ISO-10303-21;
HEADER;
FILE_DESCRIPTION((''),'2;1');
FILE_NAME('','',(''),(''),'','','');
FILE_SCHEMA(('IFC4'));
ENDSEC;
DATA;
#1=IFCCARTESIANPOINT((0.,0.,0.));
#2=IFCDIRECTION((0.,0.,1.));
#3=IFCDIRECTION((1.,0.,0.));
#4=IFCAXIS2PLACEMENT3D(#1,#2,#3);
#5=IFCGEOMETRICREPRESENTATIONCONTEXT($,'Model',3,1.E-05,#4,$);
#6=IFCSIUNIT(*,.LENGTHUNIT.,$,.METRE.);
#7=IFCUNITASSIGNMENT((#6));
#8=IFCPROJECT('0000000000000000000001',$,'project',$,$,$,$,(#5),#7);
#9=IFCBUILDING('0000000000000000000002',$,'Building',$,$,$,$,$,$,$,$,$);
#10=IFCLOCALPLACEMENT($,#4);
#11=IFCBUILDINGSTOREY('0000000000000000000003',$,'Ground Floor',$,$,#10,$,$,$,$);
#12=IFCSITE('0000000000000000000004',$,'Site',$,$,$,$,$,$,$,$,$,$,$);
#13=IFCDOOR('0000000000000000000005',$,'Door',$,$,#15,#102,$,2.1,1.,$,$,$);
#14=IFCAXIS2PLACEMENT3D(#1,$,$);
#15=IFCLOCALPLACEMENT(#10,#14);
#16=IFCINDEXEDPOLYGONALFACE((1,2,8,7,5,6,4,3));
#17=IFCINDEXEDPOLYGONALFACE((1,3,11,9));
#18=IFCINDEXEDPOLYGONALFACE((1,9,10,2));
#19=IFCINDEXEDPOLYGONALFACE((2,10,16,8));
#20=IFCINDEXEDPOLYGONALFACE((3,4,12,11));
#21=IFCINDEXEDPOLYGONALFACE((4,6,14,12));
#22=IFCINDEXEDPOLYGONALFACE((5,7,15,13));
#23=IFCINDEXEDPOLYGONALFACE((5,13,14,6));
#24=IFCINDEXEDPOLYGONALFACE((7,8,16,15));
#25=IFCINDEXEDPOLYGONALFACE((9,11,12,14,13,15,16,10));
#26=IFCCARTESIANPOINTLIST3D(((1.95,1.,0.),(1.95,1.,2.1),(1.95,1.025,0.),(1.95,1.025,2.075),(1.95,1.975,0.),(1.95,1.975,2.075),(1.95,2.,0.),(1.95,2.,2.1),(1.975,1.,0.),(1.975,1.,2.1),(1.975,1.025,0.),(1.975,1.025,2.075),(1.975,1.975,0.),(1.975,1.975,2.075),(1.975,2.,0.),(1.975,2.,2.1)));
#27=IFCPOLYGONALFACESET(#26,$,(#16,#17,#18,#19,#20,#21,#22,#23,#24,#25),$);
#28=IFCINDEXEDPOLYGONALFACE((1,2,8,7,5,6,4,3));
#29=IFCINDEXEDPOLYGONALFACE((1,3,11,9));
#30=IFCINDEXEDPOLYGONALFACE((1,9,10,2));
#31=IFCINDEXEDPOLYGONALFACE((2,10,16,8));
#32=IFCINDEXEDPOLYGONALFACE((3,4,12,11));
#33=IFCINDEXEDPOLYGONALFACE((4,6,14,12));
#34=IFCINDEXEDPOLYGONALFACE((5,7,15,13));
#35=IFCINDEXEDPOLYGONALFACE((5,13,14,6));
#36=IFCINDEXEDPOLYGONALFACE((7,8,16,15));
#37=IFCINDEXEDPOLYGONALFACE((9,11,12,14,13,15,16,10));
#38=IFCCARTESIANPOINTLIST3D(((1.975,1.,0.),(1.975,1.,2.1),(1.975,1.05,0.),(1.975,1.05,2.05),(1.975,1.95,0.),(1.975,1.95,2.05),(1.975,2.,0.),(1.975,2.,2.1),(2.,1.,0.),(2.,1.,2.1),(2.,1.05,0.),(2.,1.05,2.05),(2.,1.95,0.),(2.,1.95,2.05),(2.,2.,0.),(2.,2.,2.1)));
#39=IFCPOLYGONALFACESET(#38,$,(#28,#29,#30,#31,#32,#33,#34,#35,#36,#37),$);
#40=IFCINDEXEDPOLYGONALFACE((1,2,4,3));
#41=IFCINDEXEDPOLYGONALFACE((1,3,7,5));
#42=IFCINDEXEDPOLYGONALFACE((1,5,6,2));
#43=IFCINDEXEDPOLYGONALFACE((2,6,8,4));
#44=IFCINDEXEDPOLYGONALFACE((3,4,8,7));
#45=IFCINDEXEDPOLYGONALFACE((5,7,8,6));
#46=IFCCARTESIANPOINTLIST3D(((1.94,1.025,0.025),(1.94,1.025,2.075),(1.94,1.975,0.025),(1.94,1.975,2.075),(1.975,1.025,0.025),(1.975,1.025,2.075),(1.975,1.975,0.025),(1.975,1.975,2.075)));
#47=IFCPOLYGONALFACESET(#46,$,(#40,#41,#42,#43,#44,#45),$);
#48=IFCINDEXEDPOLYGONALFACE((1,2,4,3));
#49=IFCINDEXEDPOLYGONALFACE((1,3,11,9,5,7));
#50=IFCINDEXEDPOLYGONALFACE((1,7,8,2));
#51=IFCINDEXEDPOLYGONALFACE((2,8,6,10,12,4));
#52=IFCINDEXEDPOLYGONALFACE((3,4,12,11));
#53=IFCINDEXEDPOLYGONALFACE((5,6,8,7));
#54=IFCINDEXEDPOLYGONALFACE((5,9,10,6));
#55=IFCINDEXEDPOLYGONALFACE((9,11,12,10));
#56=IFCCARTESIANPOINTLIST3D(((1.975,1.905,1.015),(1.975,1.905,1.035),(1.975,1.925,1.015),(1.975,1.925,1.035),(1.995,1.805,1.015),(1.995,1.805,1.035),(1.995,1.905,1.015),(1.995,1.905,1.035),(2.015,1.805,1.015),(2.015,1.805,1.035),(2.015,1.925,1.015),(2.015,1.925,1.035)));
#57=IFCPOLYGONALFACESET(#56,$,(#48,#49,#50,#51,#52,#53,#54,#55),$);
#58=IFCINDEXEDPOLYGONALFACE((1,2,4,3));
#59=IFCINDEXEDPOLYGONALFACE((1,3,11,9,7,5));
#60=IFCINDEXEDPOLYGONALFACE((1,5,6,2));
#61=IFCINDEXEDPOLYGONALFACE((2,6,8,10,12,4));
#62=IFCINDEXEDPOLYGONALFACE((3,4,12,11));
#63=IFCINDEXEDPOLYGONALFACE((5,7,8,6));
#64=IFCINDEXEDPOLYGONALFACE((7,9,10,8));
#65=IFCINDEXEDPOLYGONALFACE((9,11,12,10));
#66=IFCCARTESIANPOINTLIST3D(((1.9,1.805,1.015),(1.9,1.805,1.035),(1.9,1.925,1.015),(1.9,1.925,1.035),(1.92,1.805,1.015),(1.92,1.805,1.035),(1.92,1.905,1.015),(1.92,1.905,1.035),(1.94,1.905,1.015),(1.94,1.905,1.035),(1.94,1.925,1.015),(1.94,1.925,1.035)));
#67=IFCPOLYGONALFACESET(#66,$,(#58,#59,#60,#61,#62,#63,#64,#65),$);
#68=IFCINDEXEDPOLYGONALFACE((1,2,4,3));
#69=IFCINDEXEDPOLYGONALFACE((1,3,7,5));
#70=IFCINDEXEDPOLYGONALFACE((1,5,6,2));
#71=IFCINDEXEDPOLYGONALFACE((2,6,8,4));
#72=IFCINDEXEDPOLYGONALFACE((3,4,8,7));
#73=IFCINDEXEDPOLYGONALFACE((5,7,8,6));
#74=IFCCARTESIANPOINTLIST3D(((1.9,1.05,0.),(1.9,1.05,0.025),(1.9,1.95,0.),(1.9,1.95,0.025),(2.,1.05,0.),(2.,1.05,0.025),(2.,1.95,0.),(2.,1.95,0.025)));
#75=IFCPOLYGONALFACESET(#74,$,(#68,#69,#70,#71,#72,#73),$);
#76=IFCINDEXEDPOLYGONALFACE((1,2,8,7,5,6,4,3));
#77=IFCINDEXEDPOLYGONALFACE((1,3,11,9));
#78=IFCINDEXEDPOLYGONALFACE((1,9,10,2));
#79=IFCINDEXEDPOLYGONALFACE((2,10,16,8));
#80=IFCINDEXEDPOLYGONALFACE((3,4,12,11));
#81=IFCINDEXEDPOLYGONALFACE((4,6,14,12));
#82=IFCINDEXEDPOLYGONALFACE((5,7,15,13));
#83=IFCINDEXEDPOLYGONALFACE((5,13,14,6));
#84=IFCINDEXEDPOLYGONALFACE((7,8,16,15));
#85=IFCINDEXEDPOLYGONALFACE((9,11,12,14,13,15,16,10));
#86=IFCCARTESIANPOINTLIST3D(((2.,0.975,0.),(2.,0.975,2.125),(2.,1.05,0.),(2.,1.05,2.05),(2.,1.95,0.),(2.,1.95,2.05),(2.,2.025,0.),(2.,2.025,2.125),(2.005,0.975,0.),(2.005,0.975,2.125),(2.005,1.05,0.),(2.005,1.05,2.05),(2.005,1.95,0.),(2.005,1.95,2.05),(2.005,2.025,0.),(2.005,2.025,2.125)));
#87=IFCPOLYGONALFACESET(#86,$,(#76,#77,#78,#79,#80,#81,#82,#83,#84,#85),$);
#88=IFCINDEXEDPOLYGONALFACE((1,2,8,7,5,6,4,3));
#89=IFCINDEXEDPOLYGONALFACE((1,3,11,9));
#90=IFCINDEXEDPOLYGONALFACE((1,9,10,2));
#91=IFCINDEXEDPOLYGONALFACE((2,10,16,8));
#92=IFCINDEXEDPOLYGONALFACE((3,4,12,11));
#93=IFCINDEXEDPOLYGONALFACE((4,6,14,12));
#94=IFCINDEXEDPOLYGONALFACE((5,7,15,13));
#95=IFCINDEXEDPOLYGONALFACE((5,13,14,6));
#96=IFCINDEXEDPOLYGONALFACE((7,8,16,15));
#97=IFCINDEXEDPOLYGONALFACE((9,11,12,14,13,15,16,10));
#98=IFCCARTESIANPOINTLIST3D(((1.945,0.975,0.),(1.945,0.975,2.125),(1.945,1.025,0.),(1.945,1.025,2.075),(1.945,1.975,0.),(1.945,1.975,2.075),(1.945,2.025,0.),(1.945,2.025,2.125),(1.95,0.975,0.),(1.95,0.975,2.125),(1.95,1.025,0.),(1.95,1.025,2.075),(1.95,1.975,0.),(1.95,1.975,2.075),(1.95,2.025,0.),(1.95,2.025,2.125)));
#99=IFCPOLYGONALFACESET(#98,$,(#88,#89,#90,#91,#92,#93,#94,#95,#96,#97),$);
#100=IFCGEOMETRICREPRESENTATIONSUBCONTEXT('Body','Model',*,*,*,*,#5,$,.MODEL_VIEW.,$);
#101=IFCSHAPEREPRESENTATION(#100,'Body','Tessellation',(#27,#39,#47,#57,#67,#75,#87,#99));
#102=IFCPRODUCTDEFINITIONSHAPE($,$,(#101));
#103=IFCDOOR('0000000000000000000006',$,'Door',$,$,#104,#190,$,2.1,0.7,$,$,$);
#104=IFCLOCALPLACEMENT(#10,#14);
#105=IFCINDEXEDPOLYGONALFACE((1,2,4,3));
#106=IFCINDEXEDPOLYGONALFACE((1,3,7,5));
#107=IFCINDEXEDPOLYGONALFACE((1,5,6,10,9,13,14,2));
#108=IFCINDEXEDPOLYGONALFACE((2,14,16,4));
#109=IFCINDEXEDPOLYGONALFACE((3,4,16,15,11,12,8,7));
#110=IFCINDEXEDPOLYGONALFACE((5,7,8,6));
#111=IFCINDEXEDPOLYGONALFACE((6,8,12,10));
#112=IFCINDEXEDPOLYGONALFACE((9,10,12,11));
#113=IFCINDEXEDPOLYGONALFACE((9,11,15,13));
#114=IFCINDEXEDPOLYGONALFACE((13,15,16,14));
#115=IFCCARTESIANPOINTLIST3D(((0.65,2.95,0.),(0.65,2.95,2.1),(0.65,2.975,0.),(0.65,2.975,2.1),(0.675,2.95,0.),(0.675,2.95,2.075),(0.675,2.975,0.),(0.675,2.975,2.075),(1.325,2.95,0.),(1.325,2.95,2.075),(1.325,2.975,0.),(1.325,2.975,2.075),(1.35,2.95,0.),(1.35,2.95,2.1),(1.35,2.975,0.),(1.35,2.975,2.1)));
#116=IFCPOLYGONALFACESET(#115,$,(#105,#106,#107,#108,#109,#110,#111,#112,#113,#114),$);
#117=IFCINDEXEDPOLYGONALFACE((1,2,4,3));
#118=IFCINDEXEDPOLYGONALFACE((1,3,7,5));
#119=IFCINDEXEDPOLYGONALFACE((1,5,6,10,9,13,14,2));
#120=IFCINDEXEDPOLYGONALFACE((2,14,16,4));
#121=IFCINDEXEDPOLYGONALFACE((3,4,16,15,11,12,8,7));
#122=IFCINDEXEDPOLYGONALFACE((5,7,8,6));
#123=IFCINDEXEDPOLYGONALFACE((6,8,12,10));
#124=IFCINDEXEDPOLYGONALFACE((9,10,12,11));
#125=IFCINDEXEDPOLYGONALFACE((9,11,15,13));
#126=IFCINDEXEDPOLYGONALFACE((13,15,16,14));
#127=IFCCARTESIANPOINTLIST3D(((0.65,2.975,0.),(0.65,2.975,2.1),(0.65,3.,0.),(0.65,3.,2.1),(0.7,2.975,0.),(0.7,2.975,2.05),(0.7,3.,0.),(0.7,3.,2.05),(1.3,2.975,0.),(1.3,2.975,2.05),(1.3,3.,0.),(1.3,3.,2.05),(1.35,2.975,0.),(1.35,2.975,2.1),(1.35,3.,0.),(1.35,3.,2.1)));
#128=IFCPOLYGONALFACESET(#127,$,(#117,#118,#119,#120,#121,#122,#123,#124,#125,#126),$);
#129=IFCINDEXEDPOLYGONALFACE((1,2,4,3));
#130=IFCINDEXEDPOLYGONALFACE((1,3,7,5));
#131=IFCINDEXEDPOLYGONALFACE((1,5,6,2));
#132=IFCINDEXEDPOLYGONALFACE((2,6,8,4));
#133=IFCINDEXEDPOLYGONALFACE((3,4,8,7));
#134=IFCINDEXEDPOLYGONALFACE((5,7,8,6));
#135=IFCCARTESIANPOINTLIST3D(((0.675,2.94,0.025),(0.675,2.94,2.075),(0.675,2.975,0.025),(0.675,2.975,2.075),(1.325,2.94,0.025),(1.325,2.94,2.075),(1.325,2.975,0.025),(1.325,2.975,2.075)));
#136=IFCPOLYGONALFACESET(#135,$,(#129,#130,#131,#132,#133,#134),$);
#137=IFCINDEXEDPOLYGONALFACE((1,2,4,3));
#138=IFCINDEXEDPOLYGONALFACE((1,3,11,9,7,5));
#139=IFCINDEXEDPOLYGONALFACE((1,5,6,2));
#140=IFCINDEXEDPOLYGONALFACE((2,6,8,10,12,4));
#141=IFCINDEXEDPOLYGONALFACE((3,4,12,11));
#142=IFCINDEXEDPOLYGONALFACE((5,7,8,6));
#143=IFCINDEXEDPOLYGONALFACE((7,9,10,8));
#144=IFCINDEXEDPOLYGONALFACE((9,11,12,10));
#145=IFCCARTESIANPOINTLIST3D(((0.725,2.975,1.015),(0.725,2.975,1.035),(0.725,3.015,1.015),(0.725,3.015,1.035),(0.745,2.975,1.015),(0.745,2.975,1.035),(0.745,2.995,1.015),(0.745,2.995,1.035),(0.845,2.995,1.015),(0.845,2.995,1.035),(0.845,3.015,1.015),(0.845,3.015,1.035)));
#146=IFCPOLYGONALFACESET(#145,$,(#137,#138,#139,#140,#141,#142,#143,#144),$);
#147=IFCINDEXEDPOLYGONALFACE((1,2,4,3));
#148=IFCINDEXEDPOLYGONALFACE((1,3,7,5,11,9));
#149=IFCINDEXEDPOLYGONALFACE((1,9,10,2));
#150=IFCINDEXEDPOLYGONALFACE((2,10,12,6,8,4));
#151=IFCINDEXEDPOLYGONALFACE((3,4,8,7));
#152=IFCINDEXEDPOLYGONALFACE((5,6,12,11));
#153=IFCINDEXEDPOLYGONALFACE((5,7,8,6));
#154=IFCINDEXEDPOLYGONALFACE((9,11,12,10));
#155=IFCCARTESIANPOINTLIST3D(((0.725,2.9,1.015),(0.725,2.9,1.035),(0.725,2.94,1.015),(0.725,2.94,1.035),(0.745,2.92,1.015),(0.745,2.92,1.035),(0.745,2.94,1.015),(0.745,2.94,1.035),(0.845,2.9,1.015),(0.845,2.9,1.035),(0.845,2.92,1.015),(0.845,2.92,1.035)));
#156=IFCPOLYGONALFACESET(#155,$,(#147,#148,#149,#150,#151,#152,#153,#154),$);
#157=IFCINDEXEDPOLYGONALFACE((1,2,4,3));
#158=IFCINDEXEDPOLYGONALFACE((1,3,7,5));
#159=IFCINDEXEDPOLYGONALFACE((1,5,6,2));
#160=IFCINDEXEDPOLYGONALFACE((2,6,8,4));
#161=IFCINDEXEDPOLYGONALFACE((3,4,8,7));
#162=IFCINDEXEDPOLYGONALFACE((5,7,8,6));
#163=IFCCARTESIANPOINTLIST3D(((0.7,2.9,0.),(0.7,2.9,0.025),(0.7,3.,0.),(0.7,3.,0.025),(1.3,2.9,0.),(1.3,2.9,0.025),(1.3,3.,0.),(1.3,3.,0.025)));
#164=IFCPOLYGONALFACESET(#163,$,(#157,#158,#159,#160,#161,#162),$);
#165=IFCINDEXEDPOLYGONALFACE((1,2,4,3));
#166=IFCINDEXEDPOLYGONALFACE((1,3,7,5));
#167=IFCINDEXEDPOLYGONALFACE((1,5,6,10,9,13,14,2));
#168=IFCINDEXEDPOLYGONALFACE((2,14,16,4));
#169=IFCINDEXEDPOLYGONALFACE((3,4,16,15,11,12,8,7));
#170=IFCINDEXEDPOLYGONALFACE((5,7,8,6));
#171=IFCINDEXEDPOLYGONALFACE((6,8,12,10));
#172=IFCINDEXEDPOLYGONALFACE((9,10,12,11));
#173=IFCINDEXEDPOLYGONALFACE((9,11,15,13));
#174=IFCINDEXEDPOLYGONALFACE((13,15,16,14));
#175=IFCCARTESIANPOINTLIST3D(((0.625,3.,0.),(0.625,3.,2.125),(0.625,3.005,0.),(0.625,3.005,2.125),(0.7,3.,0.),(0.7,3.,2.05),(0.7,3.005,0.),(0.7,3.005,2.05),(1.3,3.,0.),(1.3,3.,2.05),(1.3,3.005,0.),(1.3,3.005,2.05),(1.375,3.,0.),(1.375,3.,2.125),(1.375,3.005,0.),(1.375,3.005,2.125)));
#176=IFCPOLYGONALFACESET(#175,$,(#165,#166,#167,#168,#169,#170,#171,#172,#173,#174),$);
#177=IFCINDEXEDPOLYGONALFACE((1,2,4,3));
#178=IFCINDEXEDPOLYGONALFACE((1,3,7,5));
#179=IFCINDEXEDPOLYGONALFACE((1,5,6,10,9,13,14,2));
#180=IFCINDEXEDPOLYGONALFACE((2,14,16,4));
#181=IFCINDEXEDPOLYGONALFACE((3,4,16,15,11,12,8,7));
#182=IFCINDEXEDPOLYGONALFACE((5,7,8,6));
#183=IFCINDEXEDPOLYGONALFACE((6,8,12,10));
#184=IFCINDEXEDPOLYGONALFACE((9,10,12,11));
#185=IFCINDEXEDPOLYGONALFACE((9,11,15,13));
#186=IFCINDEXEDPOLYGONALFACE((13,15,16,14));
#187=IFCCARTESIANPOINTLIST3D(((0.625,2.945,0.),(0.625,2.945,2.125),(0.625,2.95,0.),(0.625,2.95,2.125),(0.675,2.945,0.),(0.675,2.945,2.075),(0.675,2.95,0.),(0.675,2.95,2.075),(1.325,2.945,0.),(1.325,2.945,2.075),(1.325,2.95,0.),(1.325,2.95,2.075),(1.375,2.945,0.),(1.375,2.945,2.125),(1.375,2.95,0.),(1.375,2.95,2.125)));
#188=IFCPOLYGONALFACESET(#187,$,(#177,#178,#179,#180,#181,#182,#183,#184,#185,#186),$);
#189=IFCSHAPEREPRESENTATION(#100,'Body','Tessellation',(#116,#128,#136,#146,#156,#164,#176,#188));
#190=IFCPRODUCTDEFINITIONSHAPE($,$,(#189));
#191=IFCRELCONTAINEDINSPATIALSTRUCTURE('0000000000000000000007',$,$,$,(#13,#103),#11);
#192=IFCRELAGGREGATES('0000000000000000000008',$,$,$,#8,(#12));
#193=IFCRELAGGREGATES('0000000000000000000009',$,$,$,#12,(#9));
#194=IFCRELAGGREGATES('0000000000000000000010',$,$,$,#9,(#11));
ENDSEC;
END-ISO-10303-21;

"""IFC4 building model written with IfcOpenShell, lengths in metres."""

from ifc_helpers import new_model, si_unit, frame, origin_with_axes, place, context, subcontext, project, spatial, line, indexed_curve, outline, extrude, element, save


model = new_model("IFC4")

# Units and contexts
model_context = context("Model", 3, precision=1e-05, world=origin_with_axes())
body_context = subcontext(model_context, "Body", "Model", "MODEL_VIEW")
ifc_project = project(units=[si_unit("LENGTHUNIT", "METRE")], contexts=[model_context])

# Site, building, storey
site = spatial("IfcSite", under=ifc_project, Name="Site")
building = spatial("IfcBuilding", under=site, Name="Building")
storey_placement = place(None, origin_with_axes())
storey = spatial("IfcBuildingStorey", under=building, at=storey_placement, Name="Ground Floor")

# Doors
door_1_placement = place(storey_placement, frame((2.0, 1.0, 0.0), z_axis=(0.0, 0.0, 1.0), x_axis=(0.0, 1.0, 0.0)))
element("IfcDoor", 1, at=door_1_placement, inside=storey, Name="Door", OverallHeight=2.1, OverallWidth=1.0, context=body_context, shape_type="SweptSolid", body=[
    extrude(outline(indexed_curve([(0.0, 0.0), (0.0, 2.1), (1.0, 2.1), (1.0, 0.0), (0.975, 0.0), (0.975, 2.075), (0.025, 2.075), (0.025, 0.0)], segments=[line(1, 2, 3, 4, 5, 6, 7, 8, 1)])), frame((0.0, 0.025, 0.0), z_axis=(0.0, -1.0, 0.0), x_axis=(1.0, 0.0, 0.0)), (0.0, 0.0, -1.0), 0.025),
    extrude(outline(indexed_curve([(0.0, 0.0), (0.0, 2.1), (1.0, 2.1), (1.0, 0.0), (0.95, 0.0), (0.95, 2.05), (0.05, 2.05), (0.05, 0.0)], segments=[line(1, 2, 3, 4, 5, 6, 7, 8, 1)])), frame((0.0, 0.0, 0.0), z_axis=(0.0, -1.0, 0.0), x_axis=(1.0, 0.0, 0.0)), (0.0, 0.0, -1.0), 0.025),
    extrude(outline(indexed_curve([(0.0, 0.0), (0.95, 0.0), (0.95, 0.035), (0.0, 0.035)], segments=[line(1, 2, 3, 4, 1)])), frame((0.025, 0.025, 0.025), z_axis=(0.0, 0.0, 1.0), x_axis=(1.0, 0.0, 0.0)), (0.0, 0.0, 1.0), 2.05),
    extrude(outline(indexed_curve([(0.0, 0.0), (0.0, -0.04), (-0.12, -0.04), (-0.12, -0.02), (-0.02, -0.02), (-0.02, 0.0)], segments=[line(1, 2, 3, 4, 5, 6, 1)])), frame((0.925, 0.025, 1.015), z_axis=(0.0, 0.0, 1.0), x_axis=(1.0, 0.0, 0.0)), (0.0, 0.0, 1.0), 0.02),
    extrude(outline(indexed_curve([(0.0, 0.0), (0.0, 0.04), (-0.12, 0.04), (-0.12, 0.02), (-0.02, 0.02), (-0.02, 0.0)], segments=[line(1, 2, 3, 4, 5, 6, 1)])), frame((0.925, 0.06, 1.015), z_axis=(0.0, 0.0, 1.0), x_axis=(1.0, 0.0, 0.0)), (0.0, 0.0, 1.0), 0.02),
    extrude(outline(indexed_curve([(0.0, 0.0), (0.9, 0.0), (0.9, 0.1), (0.0, 0.1)], segments=[line(1, 2, 3, 4, 1)])), frame((0.05, 0.0, 0.0), z_axis=(0.0, 0.0, 1.0), x_axis=(1.0, 0.0, 0.0)), (0.0, 0.0, 1.0), 0.025),
    extrude(outline(indexed_curve([(0.0, 0.0), (0.0, 2.125), (1.05, 2.125), (1.05, 0.0), (0.975, 0.0), (0.975, 2.05), (0.075, 2.05), (0.075, 0.0)], segments=[line(1, 2, 3, 4, 5, 6, 7, 8, 1)])), frame((-0.025, -0.005, 0.0), z_axis=(0.0, -1.0, 0.0), x_axis=(1.0, 0.0, 0.0)), (0.0, 0.0, -1.0), 0.005),
    extrude(outline(indexed_curve([(0.0, 0.0), (0.0, 2.125), (1.05, 2.125), (1.05, 0.0), (1.0, 0.0), (1.0, 2.075), (0.05, 2.075), (0.05, 0.0)], segments=[line(1, 2, 3, 4, 5, 6, 7, 8, 1)])), frame((-0.025, 0.05, 0.0), z_axis=(0.0, -1.0, 0.0), x_axis=(1.0, 0.0, 0.0)), (0.0, 0.0, -1.0), 0.005),
])
door_2_placement = place(storey_placement, frame((1.35, 3.0, 0.0), z_axis=(0.0, 0.0, 1.0), x_axis=(-1.0, 0.0, 0.0)))
element("IfcDoor", 2, at=door_2_placement, inside=storey, Name="Door", OverallHeight=2.1, OverallWidth=0.7, context=body_context, shape_type="SweptSolid", body=[
    extrude(outline(indexed_curve([(0.0, 0.0), (0.0, 2.1), (0.7, 2.1), (0.7, 0.0), (0.675, 0.0), (0.675, 2.075), (0.025, 2.075), (0.025, 0.0)], segments=[line(1, 2, 3, 4, 5, 6, 7, 8, 1)])), frame((0.0, 0.025, 0.0), z_axis=(0.0, -1.0, 0.0), x_axis=(1.0, 0.0, 0.0)), (0.0, 0.0, -1.0), 0.025),
    extrude(outline(indexed_curve([(0.0, 0.0), (0.0, 2.1), (0.7, 2.1), (0.7, 0.0), (0.65, 0.0), (0.65, 2.05), (0.05, 2.05), (0.05, 0.0)], segments=[line(1, 2, 3, 4, 5, 6, 7, 8, 1)])), frame((0.0, 0.0, 0.0), z_axis=(0.0, -1.0, 0.0), x_axis=(1.0, 0.0, 0.0)), (0.0, 0.0, -1.0), 0.025),
    extrude(outline(indexed_curve([(0.0, 0.0), (0.65, 0.0), (0.65, 0.035), (0.0, 0.035)], segments=[line(1, 2, 3, 4, 1)])), frame((0.025, 0.025, 0.025), z_axis=(0.0, 0.0, 1.0), x_axis=(1.0, 0.0, 0.0)), (0.0, 0.0, 1.0), 2.05),
    extrude(outline(indexed_curve([(0.0, 0.0), (0.0, -0.04), (-0.12, -0.04), (-0.12, -0.02), (-0.02, -0.02), (-0.02, 0.0)], segments=[line(1, 2, 3, 4, 5, 6, 1)])), frame((0.625, 0.025, 1.015), z_axis=(0.0, 0.0, 1.0), x_axis=(1.0, 0.0, 0.0)), (0.0, 0.0, 1.0), 0.02),
    extrude(outline(indexed_curve([(0.0, 0.0), (0.0, 0.04), (-0.12, 0.04), (-0.12, 0.02), (-0.02, 0.02), (-0.02, 0.0)], segments=[line(1, 2, 3, 4, 5, 6, 1)])), frame((0.625, 0.06, 1.015), z_axis=(0.0, 0.0, 1.0), x_axis=(1.0, 0.0, 0.0)), (0.0, 0.0, 1.0), 0.02),
    extrude(outline(indexed_curve([(0.0, 0.0), (0.6, 0.0), (0.6, 0.1), (0.0, 0.1)], segments=[line(1, 2, 3, 4, 1)])), frame((0.05, 0.0, 0.0), z_axis=(0.0, 0.0, 1.0), x_axis=(1.0, 0.0, 0.0)), (0.0, 0.0, 1.0), 0.025),
    extrude(outline(indexed_curve([(0.0, 0.0), (0.0, 2.125), (0.75, 2.125), (0.75, 0.0), (0.675, 0.0), (0.675, 2.05), (0.075, 2.05), (0.075, 0.0)], segments=[line(1, 2, 3, 4, 5, 6, 7, 8, 1)])), frame((-0.025, -0.005, 0.0), z_axis=(0.0, -1.0, 0.0), x_axis=(1.0, 0.0, 0.0)), (0.0, 0.0, -1.0), 0.005),
    extrude(outline(indexed_curve([(0.0, 0.0), (0.0, 2.125), (0.75, 2.125), (0.75, 0.0), (0.7, 0.0), (0.7, 2.075), (0.05, 2.075), (0.05, 0.0)], segments=[line(1, 2, 3, 4, 5, 6, 7, 8, 1)])), frame((-0.025, 0.05, 0.0), z_axis=(0.0, -1.0, 0.0), x_axis=(1.0, 0.0, 0.0)), (0.0, 0.0, -1.0), 0.005),
])

save(model, "model.ifc")
